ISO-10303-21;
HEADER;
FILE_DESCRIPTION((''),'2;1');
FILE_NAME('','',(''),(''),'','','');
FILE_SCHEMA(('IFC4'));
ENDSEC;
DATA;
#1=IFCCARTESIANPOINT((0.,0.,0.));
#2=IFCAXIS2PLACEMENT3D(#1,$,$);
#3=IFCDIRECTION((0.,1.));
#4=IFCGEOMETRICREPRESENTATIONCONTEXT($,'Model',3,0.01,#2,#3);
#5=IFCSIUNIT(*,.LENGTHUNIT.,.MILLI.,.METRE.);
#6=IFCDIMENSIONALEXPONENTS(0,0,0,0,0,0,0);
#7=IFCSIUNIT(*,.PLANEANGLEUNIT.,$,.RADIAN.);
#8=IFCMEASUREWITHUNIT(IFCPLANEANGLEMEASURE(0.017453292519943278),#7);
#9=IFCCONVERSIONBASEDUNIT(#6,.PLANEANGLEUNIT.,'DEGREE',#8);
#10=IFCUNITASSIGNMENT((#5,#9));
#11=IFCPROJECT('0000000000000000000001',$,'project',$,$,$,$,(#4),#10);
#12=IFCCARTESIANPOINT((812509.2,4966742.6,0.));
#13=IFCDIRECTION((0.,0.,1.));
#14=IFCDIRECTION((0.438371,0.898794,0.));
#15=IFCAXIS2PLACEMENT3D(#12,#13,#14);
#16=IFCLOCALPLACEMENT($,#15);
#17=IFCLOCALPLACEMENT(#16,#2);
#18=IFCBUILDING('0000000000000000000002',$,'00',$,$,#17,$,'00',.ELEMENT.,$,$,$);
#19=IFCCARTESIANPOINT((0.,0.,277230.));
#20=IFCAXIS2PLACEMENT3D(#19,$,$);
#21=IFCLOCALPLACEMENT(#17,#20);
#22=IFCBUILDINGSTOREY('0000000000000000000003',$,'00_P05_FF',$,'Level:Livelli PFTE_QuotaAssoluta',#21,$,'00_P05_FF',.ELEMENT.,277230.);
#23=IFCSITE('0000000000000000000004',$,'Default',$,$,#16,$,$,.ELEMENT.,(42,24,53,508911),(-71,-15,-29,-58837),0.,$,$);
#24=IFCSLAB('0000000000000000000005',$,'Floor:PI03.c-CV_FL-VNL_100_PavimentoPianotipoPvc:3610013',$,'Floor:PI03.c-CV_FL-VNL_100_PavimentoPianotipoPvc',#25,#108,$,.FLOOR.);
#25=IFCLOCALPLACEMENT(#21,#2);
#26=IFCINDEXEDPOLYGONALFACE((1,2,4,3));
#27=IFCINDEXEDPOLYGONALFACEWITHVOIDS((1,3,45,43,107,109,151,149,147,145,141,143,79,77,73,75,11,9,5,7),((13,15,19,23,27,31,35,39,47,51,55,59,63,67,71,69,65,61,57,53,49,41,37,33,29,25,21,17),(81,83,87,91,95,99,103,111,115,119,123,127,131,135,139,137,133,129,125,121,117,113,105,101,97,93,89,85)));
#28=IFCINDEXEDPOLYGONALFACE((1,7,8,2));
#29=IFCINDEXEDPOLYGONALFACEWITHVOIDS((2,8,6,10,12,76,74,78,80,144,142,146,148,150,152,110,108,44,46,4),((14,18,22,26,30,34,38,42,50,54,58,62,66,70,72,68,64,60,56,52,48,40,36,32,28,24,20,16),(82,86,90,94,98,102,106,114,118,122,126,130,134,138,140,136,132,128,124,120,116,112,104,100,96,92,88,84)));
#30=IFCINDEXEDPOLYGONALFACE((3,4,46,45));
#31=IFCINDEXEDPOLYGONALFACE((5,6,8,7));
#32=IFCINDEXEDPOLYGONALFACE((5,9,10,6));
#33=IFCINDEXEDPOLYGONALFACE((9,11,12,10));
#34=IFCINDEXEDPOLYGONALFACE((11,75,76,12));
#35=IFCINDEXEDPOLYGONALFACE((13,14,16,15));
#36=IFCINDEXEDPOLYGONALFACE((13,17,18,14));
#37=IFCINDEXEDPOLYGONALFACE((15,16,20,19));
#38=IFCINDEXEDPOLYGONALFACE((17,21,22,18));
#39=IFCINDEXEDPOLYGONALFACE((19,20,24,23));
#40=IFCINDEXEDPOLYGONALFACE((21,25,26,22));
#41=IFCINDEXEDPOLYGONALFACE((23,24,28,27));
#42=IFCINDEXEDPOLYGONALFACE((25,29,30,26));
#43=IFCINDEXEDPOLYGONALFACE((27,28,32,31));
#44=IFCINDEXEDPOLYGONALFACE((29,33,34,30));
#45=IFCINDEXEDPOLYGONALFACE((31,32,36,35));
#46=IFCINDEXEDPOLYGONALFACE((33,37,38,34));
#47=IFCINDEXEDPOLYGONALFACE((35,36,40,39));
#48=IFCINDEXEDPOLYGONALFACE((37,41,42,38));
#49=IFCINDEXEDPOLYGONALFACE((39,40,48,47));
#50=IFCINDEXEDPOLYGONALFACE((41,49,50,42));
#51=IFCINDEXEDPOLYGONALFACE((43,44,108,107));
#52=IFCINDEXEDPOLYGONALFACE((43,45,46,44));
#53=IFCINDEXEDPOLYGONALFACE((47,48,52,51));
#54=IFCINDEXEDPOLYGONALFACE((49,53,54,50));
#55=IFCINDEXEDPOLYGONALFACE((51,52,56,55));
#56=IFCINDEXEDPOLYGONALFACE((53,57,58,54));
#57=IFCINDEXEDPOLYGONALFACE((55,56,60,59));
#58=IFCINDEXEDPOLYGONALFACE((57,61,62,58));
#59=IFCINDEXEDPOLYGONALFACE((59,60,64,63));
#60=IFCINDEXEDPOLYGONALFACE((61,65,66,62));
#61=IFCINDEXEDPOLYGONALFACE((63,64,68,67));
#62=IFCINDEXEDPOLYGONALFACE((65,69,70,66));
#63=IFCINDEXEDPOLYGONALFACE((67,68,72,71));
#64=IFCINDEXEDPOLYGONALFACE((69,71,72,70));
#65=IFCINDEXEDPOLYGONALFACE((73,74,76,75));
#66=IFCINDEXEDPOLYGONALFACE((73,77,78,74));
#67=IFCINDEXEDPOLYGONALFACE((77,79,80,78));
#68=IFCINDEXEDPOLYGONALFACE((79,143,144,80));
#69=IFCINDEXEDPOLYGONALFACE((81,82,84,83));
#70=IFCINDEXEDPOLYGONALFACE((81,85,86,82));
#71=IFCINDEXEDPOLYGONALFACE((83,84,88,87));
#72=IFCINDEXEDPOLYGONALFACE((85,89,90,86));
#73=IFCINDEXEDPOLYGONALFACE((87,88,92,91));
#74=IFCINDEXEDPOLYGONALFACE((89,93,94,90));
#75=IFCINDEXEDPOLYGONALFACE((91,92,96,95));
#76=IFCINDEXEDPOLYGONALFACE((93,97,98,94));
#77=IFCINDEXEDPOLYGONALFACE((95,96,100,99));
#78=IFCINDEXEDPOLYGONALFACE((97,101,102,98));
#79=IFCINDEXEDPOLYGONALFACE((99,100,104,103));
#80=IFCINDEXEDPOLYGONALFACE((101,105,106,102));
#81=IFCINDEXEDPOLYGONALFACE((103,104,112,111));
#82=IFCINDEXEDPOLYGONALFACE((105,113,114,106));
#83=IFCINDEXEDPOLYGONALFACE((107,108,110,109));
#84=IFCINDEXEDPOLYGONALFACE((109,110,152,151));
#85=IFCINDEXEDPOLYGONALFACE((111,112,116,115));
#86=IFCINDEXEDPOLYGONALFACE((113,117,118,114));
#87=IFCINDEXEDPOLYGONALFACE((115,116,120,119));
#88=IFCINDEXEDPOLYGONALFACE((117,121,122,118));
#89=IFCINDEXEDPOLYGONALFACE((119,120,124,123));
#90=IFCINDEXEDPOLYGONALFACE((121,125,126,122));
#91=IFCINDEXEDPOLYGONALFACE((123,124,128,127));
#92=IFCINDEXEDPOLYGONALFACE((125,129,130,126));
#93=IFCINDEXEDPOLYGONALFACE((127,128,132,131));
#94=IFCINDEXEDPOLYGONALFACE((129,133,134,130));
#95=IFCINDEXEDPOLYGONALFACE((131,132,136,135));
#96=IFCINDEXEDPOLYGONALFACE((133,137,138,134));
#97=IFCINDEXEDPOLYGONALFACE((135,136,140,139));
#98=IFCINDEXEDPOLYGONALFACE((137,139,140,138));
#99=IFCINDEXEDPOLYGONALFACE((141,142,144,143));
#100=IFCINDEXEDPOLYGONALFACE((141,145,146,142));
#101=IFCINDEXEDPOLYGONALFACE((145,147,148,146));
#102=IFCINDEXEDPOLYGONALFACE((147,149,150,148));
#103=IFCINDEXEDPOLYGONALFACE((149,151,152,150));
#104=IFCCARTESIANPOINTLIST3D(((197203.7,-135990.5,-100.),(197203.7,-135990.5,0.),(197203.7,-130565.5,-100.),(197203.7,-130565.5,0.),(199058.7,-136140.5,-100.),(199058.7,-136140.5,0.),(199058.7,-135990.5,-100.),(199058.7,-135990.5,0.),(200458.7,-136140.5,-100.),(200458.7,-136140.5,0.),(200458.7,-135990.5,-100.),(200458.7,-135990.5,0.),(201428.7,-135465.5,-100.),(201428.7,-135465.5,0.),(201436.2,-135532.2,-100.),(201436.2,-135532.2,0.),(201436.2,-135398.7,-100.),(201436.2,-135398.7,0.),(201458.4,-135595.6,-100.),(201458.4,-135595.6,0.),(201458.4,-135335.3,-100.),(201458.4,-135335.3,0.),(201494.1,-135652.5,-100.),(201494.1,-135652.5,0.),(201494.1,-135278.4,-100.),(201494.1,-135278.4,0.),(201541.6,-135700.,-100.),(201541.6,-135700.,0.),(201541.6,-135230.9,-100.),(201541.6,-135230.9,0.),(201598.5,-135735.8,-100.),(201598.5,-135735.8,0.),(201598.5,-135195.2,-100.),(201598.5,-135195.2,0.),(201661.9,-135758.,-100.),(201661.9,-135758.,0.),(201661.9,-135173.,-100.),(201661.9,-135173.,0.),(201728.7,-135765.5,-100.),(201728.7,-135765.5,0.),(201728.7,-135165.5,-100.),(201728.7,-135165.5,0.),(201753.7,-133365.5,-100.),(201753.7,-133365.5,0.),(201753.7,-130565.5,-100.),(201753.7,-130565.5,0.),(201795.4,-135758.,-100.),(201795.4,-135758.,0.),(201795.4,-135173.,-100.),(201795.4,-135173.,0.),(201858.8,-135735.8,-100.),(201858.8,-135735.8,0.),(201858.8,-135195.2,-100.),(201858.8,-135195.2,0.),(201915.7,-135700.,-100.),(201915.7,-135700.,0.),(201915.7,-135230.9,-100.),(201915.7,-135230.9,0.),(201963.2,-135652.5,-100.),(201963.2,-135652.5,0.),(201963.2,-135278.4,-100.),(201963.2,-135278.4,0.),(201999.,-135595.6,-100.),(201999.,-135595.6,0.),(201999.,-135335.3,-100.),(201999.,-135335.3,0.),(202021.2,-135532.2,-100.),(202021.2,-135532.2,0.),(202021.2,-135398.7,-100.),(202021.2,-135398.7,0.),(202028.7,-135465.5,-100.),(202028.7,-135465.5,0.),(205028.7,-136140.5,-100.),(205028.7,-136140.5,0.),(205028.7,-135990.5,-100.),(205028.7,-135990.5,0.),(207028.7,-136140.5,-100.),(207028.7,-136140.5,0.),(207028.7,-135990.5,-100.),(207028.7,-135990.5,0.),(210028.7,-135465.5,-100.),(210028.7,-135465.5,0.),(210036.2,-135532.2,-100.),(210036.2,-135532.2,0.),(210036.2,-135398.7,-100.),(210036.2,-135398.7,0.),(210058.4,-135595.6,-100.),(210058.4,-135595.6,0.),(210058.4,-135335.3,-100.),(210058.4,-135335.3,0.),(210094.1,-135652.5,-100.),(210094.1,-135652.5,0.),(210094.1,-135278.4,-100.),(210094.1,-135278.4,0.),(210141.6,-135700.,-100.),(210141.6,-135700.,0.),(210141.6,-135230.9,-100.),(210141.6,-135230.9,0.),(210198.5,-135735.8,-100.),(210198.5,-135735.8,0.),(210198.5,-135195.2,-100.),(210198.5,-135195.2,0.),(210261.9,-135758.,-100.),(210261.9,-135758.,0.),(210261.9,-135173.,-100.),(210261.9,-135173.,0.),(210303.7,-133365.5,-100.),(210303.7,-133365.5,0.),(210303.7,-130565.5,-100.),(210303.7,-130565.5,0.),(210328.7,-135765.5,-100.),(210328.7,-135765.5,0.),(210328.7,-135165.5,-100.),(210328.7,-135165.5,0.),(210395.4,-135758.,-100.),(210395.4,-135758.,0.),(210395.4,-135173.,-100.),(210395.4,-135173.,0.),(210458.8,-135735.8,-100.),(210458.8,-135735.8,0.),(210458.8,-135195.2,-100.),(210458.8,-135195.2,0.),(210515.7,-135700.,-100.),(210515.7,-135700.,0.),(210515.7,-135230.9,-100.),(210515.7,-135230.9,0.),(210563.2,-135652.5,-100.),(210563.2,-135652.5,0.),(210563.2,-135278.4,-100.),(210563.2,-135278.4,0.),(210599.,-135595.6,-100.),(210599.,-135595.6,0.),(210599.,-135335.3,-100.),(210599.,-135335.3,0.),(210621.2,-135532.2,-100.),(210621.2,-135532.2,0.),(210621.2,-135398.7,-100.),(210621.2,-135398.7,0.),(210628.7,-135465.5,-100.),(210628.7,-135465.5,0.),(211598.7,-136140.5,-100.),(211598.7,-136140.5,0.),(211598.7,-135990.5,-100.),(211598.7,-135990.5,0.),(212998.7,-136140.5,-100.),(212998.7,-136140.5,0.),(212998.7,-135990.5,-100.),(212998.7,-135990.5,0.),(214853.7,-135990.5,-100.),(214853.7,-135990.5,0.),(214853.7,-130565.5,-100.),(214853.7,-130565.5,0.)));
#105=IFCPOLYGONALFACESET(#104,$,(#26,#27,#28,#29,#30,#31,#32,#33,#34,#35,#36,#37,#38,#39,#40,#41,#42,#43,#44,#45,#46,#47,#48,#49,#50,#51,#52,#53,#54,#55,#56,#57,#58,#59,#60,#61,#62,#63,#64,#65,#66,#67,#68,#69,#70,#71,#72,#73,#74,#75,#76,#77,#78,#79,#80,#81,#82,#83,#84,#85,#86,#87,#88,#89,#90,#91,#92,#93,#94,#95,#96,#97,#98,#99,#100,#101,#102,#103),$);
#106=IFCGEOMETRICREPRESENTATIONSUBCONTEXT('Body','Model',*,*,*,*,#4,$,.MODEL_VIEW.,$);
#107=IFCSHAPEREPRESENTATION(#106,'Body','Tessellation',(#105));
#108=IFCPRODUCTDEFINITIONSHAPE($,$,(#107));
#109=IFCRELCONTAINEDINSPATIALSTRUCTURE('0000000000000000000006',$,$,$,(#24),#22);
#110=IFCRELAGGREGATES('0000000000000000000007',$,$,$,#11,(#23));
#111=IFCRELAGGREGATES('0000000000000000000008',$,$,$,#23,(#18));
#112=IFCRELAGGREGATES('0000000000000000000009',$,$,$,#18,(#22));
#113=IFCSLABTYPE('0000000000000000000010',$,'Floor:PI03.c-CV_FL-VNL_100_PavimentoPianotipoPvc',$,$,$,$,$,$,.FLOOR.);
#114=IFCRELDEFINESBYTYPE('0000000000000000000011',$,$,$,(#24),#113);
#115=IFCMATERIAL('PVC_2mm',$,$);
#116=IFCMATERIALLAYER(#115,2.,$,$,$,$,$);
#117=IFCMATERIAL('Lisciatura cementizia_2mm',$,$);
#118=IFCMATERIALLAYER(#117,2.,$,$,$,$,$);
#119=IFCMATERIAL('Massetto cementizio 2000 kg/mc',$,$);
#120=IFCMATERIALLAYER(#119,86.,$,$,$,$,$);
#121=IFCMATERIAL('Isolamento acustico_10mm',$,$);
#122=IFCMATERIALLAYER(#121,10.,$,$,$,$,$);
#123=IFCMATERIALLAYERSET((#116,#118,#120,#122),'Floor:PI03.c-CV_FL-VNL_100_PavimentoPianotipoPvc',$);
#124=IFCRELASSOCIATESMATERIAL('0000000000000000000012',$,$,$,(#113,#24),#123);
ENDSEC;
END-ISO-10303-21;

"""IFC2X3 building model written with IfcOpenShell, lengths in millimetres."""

from ifc_helpers import new_model, entity, si_unit, converted_unit, direction, frame, frame_2d, origin, place, context, subcontext, project, spatial, polyline, circle, outline, extrude, material, layer, layer_set, layer_usage, type_object, element, save


model = new_model("IFC2X3")

# Units and contexts
model_context = context("Model", 3, precision=0.01, world=origin(), true_north=direction((0.0, 1.0)))
body_context = subcontext(model_context, "Body", "Model", "MODEL_VIEW")
ifc_project = project(units=[si_unit("LENGTHUNIT", "METRE", prefix="MILLI"), converted_unit("PLANEANGLEUNIT", "DEGREE", entity("IfcPlaneAngleMeasure", 0.017453292519943278), si_unit("PLANEANGLEUNIT", "RADIAN"), dimensions=[0, 0, 0, 0, 0, 0, 0])], contexts=[model_context])

# Site, building, storey
site_placement = place(None, frame((812509.2, 4966742.6, 0.0), z_axis=(0.0, 0.0, 1.0), x_axis=(0.438371, 0.898794, 0.0)))
site = spatial("IfcSite", under=ifc_project, at=site_placement, Name="Default", CompositionType="ELEMENT", RefLatitude=(42, 24, 53, 508911), RefLongitude=(-71, -15, -29, -58837), RefElevation=0.0)
building_placement = place(site_placement, origin())
building = spatial("IfcBuilding", under=site, at=building_placement, Name="00", LongName="00", CompositionType="ELEMENT")
storey_placement = place(building_placement, frame((0.0, 0.0, 277230.0)))
storey = spatial("IfcBuildingStorey", under=building, at=storey_placement, Name="00_P05_FF", ObjectType="Level:Livelli PFTE_QuotaAssoluta", LongName="00_P05_FF", CompositionType="ELEMENT", Elevation=277230.0)

# Slab, openings
ifc_material_1 = material(Name="Massetto cementizio 2000 kg/mc")
ifc_material_2 = material(Name="Isolamento acustico_10mm")
ifc_material_3 = material(Name="PVC_2mm")
ifc_layer_1 = layer(ifc_material_3, 2.0)
ifc_material_4 = material(Name="Lisciatura cementizia_2mm")
ifc_layer_2 = layer(ifc_material_4, 2.0)
ifc_layer_3 = layer(ifc_material_1, 86.0)
ifc_layer_4 = layer(ifc_material_2, 10.0)
ifc_layer_set_1 = layer_set([ifc_layer_1, ifc_layer_2, ifc_layer_3, ifc_layer_4], Name="Floor:PI03.c-CV_FL-VNL_100_PavimentoPianotipoPvc")
slab_type_1 = type_object("IfcSlabType", Name="Floor:PI03.c-CV_FL-VNL_100_PavimentoPianotipoPvc", PredefinedType="FLOOR", material=ifc_layer_set_1)
ifc_layer_usage_1 = layer_usage(ifc_layer_set_1, "AXIS3", "POSITIVE", 0.0)
slab_1_placement = place(storey_placement, frame((197203.7, -136140.5, -100.0)))
slab_1 = element("IfcSlab", 1, at=slab_1_placement, inside=storey, type_object=slab_type_1, material=ifc_layer_usage_1, Name="Floor:PI03.c-CV_FL-VNL_100_PavimentoPianotipoPvc:3610013", ObjectType="Floor:PI03.c-CV_FL-VNL_100_PavimentoPianotipoPvc", PredefinedType="FLOOR", context=body_context, shape_type="SweptSolid", body=[
    extrude(outline(polyline([(-6970.0, -2637.5), (-6970.0, -2787.5), (-5570.0, -2787.5), (-5570.0, -2637.5), (-1000.0, -2637.5), (-1000.0, -2787.5), (1000.0, -2787.5), (1000.0, -2637.5), (5570.0, -2637.5), (5570.0, -2787.5), (6970.0, -2787.5), (6970.0, -2637.5), (8825.0, -2637.5), (8825.0, 2787.5), (4275.0, 2787.5), (4275.0, -12.5), (-4275.0, -12.5), (-4275.0, 2787.5), (-8825.0, 2787.5), (-8825.0, -2637.5), (-6970.0, -2637.5)])), frame((8825.0, 2787.5, 100.0), z_axis=(0.0, 0.0, -1.0), x_axis=(-1.0, 0.0, 0.0)), (0.0, 0.0, 1.0), 100.0),
])
opening_1_placement = place(slab_1_placement, origin())
element("IfcOpeningElement", 2, at=opening_1_placement, cuts=slab_1, ObjectType="Opening", context=body_context, shape_type="SweptSolid", body=[
    extrude(circle(Radius=300.0, at=frame_2d((0.0, 0.0), x_axis=(1.0, 0.0))), frame((13125.0, 675.0, 100.0), z_axis=(0.0, 0.0, -1.0), x_axis=(1.0, 0.0, 0.0)), (0.0, 0.0, 1.0), 100.0),
])
opening_2_placement = place(slab_1_placement, origin())
element("IfcOpeningElement", 3, at=opening_2_placement, cuts=slab_1, ObjectType="Opening", context=body_context, shape_type="SweptSolid", body=[
    extrude(circle(Radius=300.0, at=frame_2d((0.0, 0.0), x_axis=(1.0, 0.0))), frame((4525.0, 675.0, 100.0), z_axis=(0.0, 0.0, -1.0), x_axis=(1.0, 0.0, 0.0)), (0.0, 0.0, 1.0), 100.0),
])

save(model, "model.ifc")
